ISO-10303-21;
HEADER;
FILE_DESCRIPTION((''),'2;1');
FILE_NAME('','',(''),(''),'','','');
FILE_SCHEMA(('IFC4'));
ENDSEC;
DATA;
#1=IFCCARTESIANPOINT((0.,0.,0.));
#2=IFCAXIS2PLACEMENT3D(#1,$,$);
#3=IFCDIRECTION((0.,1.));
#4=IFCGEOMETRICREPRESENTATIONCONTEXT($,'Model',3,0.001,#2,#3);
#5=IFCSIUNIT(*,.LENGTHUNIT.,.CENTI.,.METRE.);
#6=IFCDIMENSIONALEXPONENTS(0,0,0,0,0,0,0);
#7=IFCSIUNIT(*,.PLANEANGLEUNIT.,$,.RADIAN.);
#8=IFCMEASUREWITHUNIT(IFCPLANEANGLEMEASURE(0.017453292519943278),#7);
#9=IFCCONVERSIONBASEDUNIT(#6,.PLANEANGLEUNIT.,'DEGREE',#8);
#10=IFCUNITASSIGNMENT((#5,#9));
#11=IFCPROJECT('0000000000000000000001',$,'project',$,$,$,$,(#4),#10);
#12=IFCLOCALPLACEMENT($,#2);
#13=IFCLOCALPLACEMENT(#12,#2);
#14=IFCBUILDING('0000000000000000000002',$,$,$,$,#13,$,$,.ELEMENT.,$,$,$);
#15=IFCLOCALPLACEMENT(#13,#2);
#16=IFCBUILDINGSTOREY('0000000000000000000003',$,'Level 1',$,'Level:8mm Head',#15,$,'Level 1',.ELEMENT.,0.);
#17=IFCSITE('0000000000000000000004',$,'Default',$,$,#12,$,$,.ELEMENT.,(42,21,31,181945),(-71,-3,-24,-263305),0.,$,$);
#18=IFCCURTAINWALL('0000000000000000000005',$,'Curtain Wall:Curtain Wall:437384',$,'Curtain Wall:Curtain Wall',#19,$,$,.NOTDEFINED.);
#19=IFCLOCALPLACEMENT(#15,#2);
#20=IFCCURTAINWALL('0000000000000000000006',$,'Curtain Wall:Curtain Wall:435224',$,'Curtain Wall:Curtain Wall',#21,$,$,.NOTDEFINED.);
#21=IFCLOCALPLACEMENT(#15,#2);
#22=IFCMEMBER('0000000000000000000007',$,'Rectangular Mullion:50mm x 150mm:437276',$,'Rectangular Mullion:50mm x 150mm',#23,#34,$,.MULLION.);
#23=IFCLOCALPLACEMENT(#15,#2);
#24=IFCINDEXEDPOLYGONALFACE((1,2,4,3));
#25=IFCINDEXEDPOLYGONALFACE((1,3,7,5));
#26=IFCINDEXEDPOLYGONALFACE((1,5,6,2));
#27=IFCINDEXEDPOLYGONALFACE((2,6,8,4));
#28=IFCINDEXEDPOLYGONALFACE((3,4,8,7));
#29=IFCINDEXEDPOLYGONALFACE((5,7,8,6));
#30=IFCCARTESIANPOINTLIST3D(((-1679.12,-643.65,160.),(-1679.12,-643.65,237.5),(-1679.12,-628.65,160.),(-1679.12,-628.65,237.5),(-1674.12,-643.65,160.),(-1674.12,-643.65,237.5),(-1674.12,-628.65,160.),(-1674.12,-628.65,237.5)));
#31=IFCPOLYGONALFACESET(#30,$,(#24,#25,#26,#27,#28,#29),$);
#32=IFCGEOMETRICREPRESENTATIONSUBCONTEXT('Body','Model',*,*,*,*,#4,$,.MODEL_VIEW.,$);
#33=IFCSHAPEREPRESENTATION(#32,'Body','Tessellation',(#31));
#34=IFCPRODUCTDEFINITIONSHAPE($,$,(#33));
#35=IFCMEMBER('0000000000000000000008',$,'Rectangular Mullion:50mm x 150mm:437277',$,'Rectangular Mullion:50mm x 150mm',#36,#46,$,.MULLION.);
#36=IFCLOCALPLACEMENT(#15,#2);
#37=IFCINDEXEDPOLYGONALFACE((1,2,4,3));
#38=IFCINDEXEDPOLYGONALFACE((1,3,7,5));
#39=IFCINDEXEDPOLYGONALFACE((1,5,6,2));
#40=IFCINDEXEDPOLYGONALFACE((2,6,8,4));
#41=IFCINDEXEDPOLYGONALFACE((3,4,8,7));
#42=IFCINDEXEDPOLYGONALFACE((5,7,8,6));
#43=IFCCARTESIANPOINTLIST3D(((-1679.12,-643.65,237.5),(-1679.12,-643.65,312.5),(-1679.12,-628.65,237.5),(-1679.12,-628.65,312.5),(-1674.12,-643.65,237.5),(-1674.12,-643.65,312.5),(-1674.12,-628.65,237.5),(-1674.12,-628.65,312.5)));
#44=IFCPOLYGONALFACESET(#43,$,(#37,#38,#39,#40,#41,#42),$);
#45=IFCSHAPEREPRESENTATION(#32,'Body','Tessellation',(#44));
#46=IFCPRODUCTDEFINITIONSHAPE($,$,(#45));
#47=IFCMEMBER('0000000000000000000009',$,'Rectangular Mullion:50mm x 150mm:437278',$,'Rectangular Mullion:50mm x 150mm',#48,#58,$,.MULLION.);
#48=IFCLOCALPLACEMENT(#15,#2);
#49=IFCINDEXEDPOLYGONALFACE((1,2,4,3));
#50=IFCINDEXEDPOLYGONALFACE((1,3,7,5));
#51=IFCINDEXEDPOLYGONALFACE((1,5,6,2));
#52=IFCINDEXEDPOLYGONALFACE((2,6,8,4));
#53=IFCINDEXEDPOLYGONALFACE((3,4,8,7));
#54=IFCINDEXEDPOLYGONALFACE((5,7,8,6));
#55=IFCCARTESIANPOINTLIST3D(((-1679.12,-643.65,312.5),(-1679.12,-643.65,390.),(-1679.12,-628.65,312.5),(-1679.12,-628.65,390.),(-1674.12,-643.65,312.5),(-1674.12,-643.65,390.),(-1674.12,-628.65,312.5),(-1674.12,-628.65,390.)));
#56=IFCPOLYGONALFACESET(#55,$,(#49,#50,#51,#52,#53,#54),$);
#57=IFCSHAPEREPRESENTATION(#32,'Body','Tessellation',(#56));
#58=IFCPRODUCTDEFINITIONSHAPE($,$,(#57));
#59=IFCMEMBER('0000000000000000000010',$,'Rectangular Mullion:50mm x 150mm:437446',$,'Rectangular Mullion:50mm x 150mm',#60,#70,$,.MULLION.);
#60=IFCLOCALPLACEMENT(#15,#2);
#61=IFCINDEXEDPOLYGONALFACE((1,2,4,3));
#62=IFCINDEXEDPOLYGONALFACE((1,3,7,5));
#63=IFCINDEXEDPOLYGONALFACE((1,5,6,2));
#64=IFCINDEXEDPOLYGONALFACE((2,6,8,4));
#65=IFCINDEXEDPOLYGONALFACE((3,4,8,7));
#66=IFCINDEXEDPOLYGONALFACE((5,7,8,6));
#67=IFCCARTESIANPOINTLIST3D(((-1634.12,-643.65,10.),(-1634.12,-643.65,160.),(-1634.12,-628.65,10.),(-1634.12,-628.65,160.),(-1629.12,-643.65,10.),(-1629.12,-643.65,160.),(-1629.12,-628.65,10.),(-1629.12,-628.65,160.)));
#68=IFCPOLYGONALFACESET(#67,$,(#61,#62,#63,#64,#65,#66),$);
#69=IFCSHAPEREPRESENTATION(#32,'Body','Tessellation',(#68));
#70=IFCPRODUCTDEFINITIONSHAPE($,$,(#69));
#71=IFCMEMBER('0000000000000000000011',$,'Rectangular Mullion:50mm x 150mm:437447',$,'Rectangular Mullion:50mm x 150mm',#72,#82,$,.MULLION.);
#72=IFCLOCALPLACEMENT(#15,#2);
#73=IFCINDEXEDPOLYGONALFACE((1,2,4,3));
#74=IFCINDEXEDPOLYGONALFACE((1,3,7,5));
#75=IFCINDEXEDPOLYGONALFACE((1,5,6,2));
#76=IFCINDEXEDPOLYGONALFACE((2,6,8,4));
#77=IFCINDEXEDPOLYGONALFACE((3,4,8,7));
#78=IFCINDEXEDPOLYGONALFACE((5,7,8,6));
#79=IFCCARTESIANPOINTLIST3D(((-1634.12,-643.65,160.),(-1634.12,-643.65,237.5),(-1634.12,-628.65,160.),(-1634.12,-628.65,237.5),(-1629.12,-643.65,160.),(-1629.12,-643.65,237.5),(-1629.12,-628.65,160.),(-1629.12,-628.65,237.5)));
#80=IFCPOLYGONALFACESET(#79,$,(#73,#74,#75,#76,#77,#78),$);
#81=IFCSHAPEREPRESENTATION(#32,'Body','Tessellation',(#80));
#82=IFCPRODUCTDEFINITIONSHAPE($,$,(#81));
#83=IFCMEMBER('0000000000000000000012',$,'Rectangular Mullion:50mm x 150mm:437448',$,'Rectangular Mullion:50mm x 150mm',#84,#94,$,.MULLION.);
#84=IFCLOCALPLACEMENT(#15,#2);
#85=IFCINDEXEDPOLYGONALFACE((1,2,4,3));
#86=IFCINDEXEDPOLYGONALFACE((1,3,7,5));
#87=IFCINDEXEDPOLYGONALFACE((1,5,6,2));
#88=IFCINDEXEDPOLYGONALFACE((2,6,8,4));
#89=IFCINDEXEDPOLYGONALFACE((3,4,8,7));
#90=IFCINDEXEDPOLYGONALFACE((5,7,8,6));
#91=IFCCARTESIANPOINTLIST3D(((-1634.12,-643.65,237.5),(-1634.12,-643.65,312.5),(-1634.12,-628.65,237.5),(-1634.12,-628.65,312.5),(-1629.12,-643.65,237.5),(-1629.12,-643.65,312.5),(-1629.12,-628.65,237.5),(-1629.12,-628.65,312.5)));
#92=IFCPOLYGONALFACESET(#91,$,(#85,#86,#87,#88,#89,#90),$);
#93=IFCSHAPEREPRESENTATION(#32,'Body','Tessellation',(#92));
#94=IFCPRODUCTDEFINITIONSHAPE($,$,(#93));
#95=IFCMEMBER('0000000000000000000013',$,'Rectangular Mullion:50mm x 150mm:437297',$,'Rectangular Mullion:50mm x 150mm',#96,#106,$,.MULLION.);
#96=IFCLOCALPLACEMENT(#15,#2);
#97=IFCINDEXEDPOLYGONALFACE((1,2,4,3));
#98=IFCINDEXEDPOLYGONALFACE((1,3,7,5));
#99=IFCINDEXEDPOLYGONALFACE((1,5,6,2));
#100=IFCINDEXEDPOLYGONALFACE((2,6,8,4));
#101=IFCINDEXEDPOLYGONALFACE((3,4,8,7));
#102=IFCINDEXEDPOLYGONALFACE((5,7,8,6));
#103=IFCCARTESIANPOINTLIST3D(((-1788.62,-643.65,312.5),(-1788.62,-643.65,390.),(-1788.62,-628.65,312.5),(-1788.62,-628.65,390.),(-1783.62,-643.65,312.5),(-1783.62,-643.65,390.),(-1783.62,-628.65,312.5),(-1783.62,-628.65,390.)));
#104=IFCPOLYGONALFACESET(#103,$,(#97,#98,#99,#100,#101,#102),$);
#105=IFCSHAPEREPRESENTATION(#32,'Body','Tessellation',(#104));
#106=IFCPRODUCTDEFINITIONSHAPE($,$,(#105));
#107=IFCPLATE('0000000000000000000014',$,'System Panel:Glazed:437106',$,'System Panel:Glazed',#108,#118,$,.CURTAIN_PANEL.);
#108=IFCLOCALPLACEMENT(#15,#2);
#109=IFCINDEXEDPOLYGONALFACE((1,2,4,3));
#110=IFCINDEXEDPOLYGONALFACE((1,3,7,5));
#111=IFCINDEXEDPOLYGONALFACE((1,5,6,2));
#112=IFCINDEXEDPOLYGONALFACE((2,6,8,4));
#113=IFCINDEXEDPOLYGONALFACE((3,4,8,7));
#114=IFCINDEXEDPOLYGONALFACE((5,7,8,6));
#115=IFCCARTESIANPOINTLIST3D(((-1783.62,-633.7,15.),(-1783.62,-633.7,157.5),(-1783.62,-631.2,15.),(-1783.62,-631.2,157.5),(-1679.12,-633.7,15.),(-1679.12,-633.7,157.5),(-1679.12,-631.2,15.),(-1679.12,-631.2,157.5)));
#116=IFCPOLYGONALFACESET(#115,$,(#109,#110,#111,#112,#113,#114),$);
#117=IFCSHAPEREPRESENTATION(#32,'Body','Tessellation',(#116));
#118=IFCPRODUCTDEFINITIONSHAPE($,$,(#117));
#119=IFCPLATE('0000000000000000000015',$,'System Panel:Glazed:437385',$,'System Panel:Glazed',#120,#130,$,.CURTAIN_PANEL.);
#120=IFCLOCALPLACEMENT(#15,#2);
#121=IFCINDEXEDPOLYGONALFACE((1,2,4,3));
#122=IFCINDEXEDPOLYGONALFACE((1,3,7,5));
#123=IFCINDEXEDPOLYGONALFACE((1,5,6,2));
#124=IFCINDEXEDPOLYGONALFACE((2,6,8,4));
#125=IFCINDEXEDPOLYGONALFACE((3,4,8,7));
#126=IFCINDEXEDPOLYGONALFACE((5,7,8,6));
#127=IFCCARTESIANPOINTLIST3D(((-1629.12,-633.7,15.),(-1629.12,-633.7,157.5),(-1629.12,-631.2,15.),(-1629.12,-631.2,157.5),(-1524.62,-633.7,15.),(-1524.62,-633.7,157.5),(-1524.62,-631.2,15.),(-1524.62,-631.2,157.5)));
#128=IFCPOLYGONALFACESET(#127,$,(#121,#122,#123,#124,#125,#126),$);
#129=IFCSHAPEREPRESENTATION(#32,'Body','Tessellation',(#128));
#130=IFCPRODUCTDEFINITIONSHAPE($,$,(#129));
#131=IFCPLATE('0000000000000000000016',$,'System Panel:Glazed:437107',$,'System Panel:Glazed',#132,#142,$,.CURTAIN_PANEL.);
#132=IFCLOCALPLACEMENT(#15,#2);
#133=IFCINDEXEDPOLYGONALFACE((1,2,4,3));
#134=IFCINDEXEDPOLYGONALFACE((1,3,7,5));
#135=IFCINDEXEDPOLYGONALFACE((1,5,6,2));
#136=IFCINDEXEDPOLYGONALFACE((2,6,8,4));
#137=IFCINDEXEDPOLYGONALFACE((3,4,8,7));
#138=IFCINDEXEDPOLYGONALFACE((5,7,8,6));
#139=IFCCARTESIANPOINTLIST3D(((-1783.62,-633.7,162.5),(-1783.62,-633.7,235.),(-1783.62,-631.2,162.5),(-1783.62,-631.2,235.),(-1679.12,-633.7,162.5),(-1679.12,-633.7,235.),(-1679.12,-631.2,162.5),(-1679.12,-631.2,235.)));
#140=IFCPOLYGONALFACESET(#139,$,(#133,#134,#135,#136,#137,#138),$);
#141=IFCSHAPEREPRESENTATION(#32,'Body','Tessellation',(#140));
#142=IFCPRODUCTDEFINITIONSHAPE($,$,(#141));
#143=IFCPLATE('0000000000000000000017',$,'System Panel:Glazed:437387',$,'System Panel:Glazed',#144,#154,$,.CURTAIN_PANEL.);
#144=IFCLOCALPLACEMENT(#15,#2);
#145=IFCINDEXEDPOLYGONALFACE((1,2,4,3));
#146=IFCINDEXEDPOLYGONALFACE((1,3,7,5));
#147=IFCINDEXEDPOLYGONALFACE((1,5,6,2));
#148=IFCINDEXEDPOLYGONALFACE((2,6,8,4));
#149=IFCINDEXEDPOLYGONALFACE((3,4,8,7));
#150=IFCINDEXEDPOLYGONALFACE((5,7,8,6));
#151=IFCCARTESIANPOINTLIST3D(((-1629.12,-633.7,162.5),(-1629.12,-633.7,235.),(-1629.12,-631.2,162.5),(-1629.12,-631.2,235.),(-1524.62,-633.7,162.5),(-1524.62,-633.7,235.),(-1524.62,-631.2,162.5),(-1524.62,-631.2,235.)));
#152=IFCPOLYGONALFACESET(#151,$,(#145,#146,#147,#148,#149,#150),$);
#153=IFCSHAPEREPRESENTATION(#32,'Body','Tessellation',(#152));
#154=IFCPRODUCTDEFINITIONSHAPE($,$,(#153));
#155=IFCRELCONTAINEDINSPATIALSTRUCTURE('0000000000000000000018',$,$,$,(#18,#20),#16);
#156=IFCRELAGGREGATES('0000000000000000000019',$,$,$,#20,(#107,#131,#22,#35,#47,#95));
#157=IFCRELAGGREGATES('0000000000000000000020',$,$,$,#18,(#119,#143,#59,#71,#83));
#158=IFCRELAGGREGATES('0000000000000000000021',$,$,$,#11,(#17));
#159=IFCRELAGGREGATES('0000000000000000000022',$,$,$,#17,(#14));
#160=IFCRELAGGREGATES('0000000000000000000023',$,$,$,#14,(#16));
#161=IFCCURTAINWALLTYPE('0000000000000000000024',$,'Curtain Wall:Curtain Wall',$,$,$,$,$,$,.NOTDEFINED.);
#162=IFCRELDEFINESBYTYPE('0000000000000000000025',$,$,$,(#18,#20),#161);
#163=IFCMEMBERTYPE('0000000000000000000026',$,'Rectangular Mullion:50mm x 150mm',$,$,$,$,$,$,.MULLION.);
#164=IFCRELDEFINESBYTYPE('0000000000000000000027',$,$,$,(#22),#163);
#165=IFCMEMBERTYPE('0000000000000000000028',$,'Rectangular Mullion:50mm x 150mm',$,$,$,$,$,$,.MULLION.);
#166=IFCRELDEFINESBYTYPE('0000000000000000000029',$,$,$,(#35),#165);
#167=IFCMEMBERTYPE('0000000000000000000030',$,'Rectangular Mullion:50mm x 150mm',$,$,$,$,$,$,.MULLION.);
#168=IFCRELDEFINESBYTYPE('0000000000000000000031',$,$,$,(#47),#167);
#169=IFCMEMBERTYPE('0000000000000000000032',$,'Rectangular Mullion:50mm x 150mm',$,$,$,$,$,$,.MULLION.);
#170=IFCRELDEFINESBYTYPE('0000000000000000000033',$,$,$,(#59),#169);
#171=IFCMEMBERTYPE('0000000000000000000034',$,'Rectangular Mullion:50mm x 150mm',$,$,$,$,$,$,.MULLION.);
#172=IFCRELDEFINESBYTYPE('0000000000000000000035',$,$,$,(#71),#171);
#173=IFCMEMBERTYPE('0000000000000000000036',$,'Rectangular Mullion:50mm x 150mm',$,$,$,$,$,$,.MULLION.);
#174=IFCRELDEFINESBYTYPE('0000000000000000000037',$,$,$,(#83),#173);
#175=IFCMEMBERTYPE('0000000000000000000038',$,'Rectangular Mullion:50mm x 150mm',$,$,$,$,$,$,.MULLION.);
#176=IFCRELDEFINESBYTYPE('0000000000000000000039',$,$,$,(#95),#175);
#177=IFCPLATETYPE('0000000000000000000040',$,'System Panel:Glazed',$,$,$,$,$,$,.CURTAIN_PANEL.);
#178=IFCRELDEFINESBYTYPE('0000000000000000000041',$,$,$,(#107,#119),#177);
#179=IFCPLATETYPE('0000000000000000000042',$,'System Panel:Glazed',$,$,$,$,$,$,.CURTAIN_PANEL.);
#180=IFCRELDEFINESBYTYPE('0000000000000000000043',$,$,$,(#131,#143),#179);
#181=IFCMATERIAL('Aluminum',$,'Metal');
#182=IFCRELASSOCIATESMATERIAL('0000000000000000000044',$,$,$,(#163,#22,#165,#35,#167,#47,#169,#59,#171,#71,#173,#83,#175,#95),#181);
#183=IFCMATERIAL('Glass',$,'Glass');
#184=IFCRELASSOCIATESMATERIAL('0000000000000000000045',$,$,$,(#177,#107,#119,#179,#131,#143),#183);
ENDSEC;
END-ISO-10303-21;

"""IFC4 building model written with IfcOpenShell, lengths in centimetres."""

from ifc_helpers import new_model, entity, si_unit, converted_unit, direction, frame, origin, place, context, subcontext, project, spatial, indexed_curve, outline, extrude, source, transform, mapped, material, type_object, type_shapes, element, aggregate, save


model = new_model("IFC4")

# Units and contexts
model_context = context("Model", 3, precision=0.001, world=origin(), true_north=direction((0.0, 1.0)))
body_context = subcontext(model_context, "Body", "Model", "MODEL_VIEW")
ifc_project = project(units=[si_unit("LENGTHUNIT", "METRE", prefix="CENTI"), converted_unit("PLANEANGLEUNIT", "DEGREE", entity("IfcPlaneAngleMeasure", 0.017453292519943278), si_unit("PLANEANGLEUNIT", "RADIAN"), dimensions=[0, 0, 0, 0, 0, 0, 0])], contexts=[model_context])

# Site, building, storey
site_placement = place(None, origin())
site = spatial("IfcSite", under=ifc_project, at=site_placement, Name="Default", CompositionType="ELEMENT", RefLatitude=(42, 21, 31, 181945), RefLongitude=(-71, -3, -24, -263305), RefElevation=0.0)
building_placement = place(site_placement, origin())
building = spatial("IfcBuilding", under=site, at=building_placement, CompositionType="ELEMENT")
storey_placement = place(building_placement, origin())
storey = spatial("IfcBuildingStorey", under=building, at=storey_placement, Name="Level 1", ObjectType="Level:8mm Head", LongName="Level 1", CompositionType="ELEMENT", Elevation=0.0)

# Curtain walls
curtain_wall_type = type_object("IfcCurtainWallType", Name="Curtain Wall:Curtain Wall", PredefinedType="NOTDEFINED")
curtain_wall_1_placement = place(storey_placement, origin())
curtain_wall_1 = element("IfcCurtainWall", 1, at=curtain_wall_1_placement, inside=storey, type_object=curtain_wall_type, Name="Curtain Wall:Curtain Wall:437384", ObjectType="Curtain Wall:Curtain Wall", PredefinedType="NOTDEFINED")
ifc_material_1 = material(Name="Aluminum", Category="Metal")
curtain_wall_2_placement = place(storey_placement, origin())
curtain_wall_2 = element("IfcCurtainWall", 2, at=curtain_wall_2_placement, inside=storey, type_object=curtain_wall_type, Name="Curtain Wall:Curtain Wall:435224", ObjectType="Curtain Wall:Curtain Wall", PredefinedType="NOTDEFINED")

# Members
member_type_1 = type_object("IfcMemberType", Name="Rectangular Mullion:50mm x 150mm", PredefinedType="MULLION", material=ifc_material_1)
shared_shape_1 = source(origin(), body_context, "Body", "SweptSolid", [
    extrude(outline(indexed_curve([(-2.5, -7.5), (2.5, -7.5), (2.5, 7.5), (-2.5, 7.5), (-2.5, -7.5)], self_intersect=False)), frame((-2.5, 0.0, -77.5), z_axis=(0.0, 0.0, 1.0), x_axis=(-1.0, 0.0, 0.0)), (0.0, 0.0, 1.0), 77.5),
])
type_shapes(member_type_1, [shared_shape_1])
member_1_placement = place(curtain_wall_2_placement, frame((-1674.12, -636.15, 160.0), z_axis=(0.0, 0.0, -1.0), x_axis=(1.0, 0.0, 0.0)))
member_1 = element("IfcMember", 3, at=member_1_placement, type_object=member_type_1, material=ifc_material_1, Name="Rectangular Mullion:50mm x 150mm:437276", ObjectType="Rectangular Mullion:50mm x 150mm", PredefinedType="MULLION", context=body_context, shape_type="MappedRepresentation", body=[
    mapped(shared_shape_1, transform((0.0, 0.0, 0.0), scale=1.0)),
])
member_type_2 = type_object("IfcMemberType", Name="Rectangular Mullion:50mm x 150mm", PredefinedType="MULLION", material=ifc_material_1)
shared_shape_2 = source(origin(), body_context, "Body", "SweptSolid", [
    extrude(outline(indexed_curve([(-2.5, -7.5), (2.5, -7.5), (2.5, 7.5), (-2.5, 7.5), (-2.5, -7.5)], self_intersect=False)), frame((-2.5, 0.0, -75.0), z_axis=(0.0, 0.0, 1.0), x_axis=(-1.0, 0.0, 0.0)), (0.0, 0.0, 1.0), 75.0),
])
type_shapes(member_type_2, [shared_shape_2])
member_2_placement = place(curtain_wall_2_placement, frame((-1674.12, -636.15, 237.5), z_axis=(0.0, 0.0, -1.0), x_axis=(1.0, 0.0, 0.0)))
member_2 = element("IfcMember", 4, at=member_2_placement, type_object=member_type_2, material=ifc_material_1, Name="Rectangular Mullion:50mm x 150mm:437277", ObjectType="Rectangular Mullion:50mm x 150mm", PredefinedType="MULLION", context=body_context, shape_type="MappedRepresentation", body=[
    mapped(shared_shape_2, transform((0.0, 0.0, 0.0), scale=1.0)),
])
member_type_3 = type_object("IfcMemberType", Name="Rectangular Mullion:50mm x 150mm", PredefinedType="MULLION", material=ifc_material_1)
shared_shape_3 = source(origin(), body_context, "Body", "SweptSolid", [
    extrude(outline(indexed_curve([(-2.5, -7.5), (2.5, -7.5), (2.5, 7.5), (-2.5, 7.5), (-2.5, -7.5)], self_intersect=False)), frame((-2.5, 0.0, -77.5), z_axis=(0.0, 0.0, 1.0), x_axis=(-1.0, 0.0, 0.0)), (0.0, 0.0, 1.0), 77.5),
])
type_shapes(member_type_3, [shared_shape_3])
member_3_placement = place(curtain_wall_2_placement, frame((-1674.12, -636.15, 312.5), z_axis=(0.0, 0.0, -1.0), x_axis=(1.0, 0.0, 0.0)))
member_3 = element("IfcMember", 5, at=member_3_placement, type_object=member_type_3, material=ifc_material_1, Name="Rectangular Mullion:50mm x 150mm:437278", ObjectType="Rectangular Mullion:50mm x 150mm", PredefinedType="MULLION", context=body_context, shape_type="MappedRepresentation", body=[
    mapped(shared_shape_3, transform((0.0, 0.0, 0.0), scale=1.0)),
])
member_type_4 = type_object("IfcMemberType", Name="Rectangular Mullion:50mm x 150mm", PredefinedType="MULLION", material=ifc_material_1)
shared_shape_4 = source(origin(), body_context, "Body", "SweptSolid", [
    extrude(outline(indexed_curve([(-2.5, -7.5), (2.5, -7.5), (2.5, 7.5), (-2.5, 7.5), (-2.5, -7.5)], self_intersect=False)), frame((-2.5, 0.0, -150.0), z_axis=(0.0, 0.0, 1.0), x_axis=(-1.0, 0.0, 0.0)), (0.0, 0.0, 1.0), 150.0),
])
type_shapes(member_type_4, [shared_shape_4])
member_4_placement = place(curtain_wall_1_placement, frame((-1634.12, -636.15, 160.0), z_axis=(0.0, 0.0, 1.0), x_axis=(-1.0, 0.0, 0.0)))
member_4 = element("IfcMember", 6, at=member_4_placement, type_object=member_type_4, material=ifc_material_1, Name="Rectangular Mullion:50mm x 150mm:437446", ObjectType="Rectangular Mullion:50mm x 150mm", PredefinedType="MULLION", context=body_context, shape_type="MappedRepresentation", body=[
    mapped(shared_shape_4, transform((0.0, 0.0, 0.0), scale=1.0)),
])
member_type_5 = type_object("IfcMemberType", Name="Rectangular Mullion:50mm x 150mm", PredefinedType="MULLION", material=ifc_material_1)
shared_shape_5 = source(origin(), body_context, "Body", "SweptSolid", [
    extrude(outline(indexed_curve([(-2.5, -7.5), (2.5, -7.5), (2.5, 7.5), (-2.5, 7.5), (-2.5, -7.5)], self_intersect=False)), frame((-2.5, 0.0, -77.5), z_axis=(0.0, 0.0, 1.0), x_axis=(-1.0, 0.0, 0.0)), (0.0, 0.0, 1.0), 77.5),
])
type_shapes(member_type_5, [shared_shape_5])
member_5_placement = place(curtain_wall_1_placement, frame((-1634.12, -636.15, 237.5), z_axis=(0.0, 0.0, 1.0), x_axis=(-1.0, 0.0, 0.0)))
member_5 = element("IfcMember", 7, at=member_5_placement, type_object=member_type_5, material=ifc_material_1, Name="Rectangular Mullion:50mm x 150mm:437447", ObjectType="Rectangular Mullion:50mm x 150mm", PredefinedType="MULLION", context=body_context, shape_type="MappedRepresentation", body=[
    mapped(shared_shape_5, transform((0.0, 0.0, 0.0), scale=1.0)),
])
member_type_6 = type_object("IfcMemberType", Name="Rectangular Mullion:50mm x 150mm", PredefinedType="MULLION", material=ifc_material_1)
shared_shape_6 = source(origin(), body_context, "Body", "SweptSolid", [
    extrude(outline(indexed_curve([(-2.5, -7.5), (2.5, -7.5), (2.5, 7.5), (-2.5, 7.5), (-2.5, -7.5)], self_intersect=False)), frame((-2.5, 0.0, -75.0), z_axis=(0.0, 0.0, 1.0), x_axis=(-1.0, 0.0, 0.0)), (0.0, 0.0, 1.0), 75.0),
])
type_shapes(member_type_6, [shared_shape_6])
member_6_placement = place(curtain_wall_1_placement, frame((-1634.12, -636.15, 312.5), z_axis=(0.0, 0.0, 1.0), x_axis=(-1.0, 0.0, 0.0)))
member_6 = element("IfcMember", 8, at=member_6_placement, type_object=member_type_6, material=ifc_material_1, Name="Rectangular Mullion:50mm x 150mm:437448", ObjectType="Rectangular Mullion:50mm x 150mm", PredefinedType="MULLION", context=body_context, shape_type="MappedRepresentation", body=[
    mapped(shared_shape_6, transform((0.0, 0.0, 0.0), scale=1.0)),
])
member_type_7 = type_object("IfcMemberType", Name="Rectangular Mullion:50mm x 150mm", PredefinedType="MULLION", material=ifc_material_1)
shared_shape_7 = source(origin(), body_context, "Body", "SweptSolid", [
    extrude(outline(indexed_curve([(-2.5, -7.5), (2.5, -7.5), (2.5, 7.5), (-2.5, 7.5), (-2.5, -7.5)], self_intersect=False)), frame((0.0, 0.0, -77.5), z_axis=(0.0, 0.0, 1.0), x_axis=(-1.0, 0.0, 0.0)), (0.0, 0.0, 1.0), 77.5),
])
type_shapes(member_type_7, [shared_shape_7])
member_7_placement = place(curtain_wall_2_placement, frame((-1786.12, -636.15, 312.5), z_axis=(0.0, 0.0, -1.0), x_axis=(1.0, 0.0, 0.0)))
member_7 = element("IfcMember", 9, at=member_7_placement, type_object=member_type_7, material=ifc_material_1, Name="Rectangular Mullion:50mm x 150mm:437297", ObjectType="Rectangular Mullion:50mm x 150mm", PredefinedType="MULLION", context=body_context, shape_type="MappedRepresentation", body=[
    mapped(shared_shape_7, transform((0.0, 0.0, 0.0), scale=1.0)),
])

# Plates
ifc_material_2 = material(Name="Glass", Category="Glass")
plate_type_1 = type_object("IfcPlateType", Name="System Panel:Glazed", PredefinedType="CURTAIN_PANEL", material=ifc_material_2)
shared_shape_8 = source(origin(), body_context, "Body", "SweptSolid", [
    extrude(outline(indexed_curve([(-1.25, -52.25), (1.25, -52.25), (1.25, 52.25), (-1.25, 52.25), (-1.25, -52.25)], self_intersect=False)), frame((0.0, 3.7, 0.0), z_axis=(0.0, 0.0, 1.0), x_axis=(0.0, 1.0, 0.0)), (0.0, 0.0, 1.0), 142.5),
])
type_shapes(plate_type_1, [shared_shape_8])
plate_1_placement = place(curtain_wall_2_placement, frame((-1731.37, -636.15, 15.0)))
plate_1 = element("IfcPlate", 10, at=plate_1_placement, type_object=plate_type_1, material=ifc_material_2, Name="System Panel:Glazed:437106", ObjectType="System Panel:Glazed", PredefinedType="CURTAIN_PANEL", context=body_context, shape_type="MappedRepresentation", body=[
    mapped(shared_shape_8, transform((0.0, 0.0, 0.0), scale=1.0)),
])
plate_2_placement = place(curtain_wall_1_placement, frame((-1576.87, -636.15, 15.0)))
plate_2 = element("IfcPlate", 11, at=plate_2_placement, type_object=plate_type_1, material=ifc_material_2, Name="System Panel:Glazed:437385", ObjectType="System Panel:Glazed", PredefinedType="CURTAIN_PANEL", context=body_context, shape_type="MappedRepresentation", body=[
    mapped(shared_shape_8, transform((0.0, 0.0, 0.0), scale=1.0)),
])
plate_type_2 = type_object("IfcPlateType", Name="System Panel:Glazed", PredefinedType="CURTAIN_PANEL", material=ifc_material_2)
shared_shape_9 = source(origin(), body_context, "Body", "SweptSolid", [
    extrude(outline(indexed_curve([(-1.25, -52.25), (1.25, -52.25), (1.25, 52.25), (-1.25, 52.25), (-1.25, -52.25)], self_intersect=False)), frame((0.0, 3.7, 0.0), z_axis=(0.0, 0.0, 1.0), x_axis=(0.0, 1.0, 0.0)), (0.0, 0.0, 1.0), 72.5),
])
type_shapes(plate_type_2, [shared_shape_9])
plate_3_placement = place(curtain_wall_2_placement, frame((-1731.37, -636.15, 162.5)))
plate_3 = element("IfcPlate", 12, at=plate_3_placement, type_object=plate_type_2, material=ifc_material_2, Name="System Panel:Glazed:437107", ObjectType="System Panel:Glazed", PredefinedType="CURTAIN_PANEL", context=body_context, shape_type="MappedRepresentation", body=[
    mapped(shared_shape_9, transform((0.0, 0.0, 0.0), scale=1.0)),
])
plate_4_placement = place(curtain_wall_1_placement, frame((-1576.87, -636.15, 162.5)))
plate_4 = element("IfcPlate", 13, at=plate_4_placement, type_object=plate_type_2, material=ifc_material_2, Name="System Panel:Glazed:437387", ObjectType="System Panel:Glazed", PredefinedType="CURTAIN_PANEL", context=body_context, shape_type="MappedRepresentation", body=[
    mapped(shared_shape_9, transform((0.0, 0.0, 0.0), scale=1.0)),
])
aggregate(curtain_wall_2, [plate_1, plate_3, member_1, member_2, member_3, member_7])
aggregate(curtain_wall_1, [plate_2, plate_4, member_4, member_5, member_6])

save(model, "model.ifc")
